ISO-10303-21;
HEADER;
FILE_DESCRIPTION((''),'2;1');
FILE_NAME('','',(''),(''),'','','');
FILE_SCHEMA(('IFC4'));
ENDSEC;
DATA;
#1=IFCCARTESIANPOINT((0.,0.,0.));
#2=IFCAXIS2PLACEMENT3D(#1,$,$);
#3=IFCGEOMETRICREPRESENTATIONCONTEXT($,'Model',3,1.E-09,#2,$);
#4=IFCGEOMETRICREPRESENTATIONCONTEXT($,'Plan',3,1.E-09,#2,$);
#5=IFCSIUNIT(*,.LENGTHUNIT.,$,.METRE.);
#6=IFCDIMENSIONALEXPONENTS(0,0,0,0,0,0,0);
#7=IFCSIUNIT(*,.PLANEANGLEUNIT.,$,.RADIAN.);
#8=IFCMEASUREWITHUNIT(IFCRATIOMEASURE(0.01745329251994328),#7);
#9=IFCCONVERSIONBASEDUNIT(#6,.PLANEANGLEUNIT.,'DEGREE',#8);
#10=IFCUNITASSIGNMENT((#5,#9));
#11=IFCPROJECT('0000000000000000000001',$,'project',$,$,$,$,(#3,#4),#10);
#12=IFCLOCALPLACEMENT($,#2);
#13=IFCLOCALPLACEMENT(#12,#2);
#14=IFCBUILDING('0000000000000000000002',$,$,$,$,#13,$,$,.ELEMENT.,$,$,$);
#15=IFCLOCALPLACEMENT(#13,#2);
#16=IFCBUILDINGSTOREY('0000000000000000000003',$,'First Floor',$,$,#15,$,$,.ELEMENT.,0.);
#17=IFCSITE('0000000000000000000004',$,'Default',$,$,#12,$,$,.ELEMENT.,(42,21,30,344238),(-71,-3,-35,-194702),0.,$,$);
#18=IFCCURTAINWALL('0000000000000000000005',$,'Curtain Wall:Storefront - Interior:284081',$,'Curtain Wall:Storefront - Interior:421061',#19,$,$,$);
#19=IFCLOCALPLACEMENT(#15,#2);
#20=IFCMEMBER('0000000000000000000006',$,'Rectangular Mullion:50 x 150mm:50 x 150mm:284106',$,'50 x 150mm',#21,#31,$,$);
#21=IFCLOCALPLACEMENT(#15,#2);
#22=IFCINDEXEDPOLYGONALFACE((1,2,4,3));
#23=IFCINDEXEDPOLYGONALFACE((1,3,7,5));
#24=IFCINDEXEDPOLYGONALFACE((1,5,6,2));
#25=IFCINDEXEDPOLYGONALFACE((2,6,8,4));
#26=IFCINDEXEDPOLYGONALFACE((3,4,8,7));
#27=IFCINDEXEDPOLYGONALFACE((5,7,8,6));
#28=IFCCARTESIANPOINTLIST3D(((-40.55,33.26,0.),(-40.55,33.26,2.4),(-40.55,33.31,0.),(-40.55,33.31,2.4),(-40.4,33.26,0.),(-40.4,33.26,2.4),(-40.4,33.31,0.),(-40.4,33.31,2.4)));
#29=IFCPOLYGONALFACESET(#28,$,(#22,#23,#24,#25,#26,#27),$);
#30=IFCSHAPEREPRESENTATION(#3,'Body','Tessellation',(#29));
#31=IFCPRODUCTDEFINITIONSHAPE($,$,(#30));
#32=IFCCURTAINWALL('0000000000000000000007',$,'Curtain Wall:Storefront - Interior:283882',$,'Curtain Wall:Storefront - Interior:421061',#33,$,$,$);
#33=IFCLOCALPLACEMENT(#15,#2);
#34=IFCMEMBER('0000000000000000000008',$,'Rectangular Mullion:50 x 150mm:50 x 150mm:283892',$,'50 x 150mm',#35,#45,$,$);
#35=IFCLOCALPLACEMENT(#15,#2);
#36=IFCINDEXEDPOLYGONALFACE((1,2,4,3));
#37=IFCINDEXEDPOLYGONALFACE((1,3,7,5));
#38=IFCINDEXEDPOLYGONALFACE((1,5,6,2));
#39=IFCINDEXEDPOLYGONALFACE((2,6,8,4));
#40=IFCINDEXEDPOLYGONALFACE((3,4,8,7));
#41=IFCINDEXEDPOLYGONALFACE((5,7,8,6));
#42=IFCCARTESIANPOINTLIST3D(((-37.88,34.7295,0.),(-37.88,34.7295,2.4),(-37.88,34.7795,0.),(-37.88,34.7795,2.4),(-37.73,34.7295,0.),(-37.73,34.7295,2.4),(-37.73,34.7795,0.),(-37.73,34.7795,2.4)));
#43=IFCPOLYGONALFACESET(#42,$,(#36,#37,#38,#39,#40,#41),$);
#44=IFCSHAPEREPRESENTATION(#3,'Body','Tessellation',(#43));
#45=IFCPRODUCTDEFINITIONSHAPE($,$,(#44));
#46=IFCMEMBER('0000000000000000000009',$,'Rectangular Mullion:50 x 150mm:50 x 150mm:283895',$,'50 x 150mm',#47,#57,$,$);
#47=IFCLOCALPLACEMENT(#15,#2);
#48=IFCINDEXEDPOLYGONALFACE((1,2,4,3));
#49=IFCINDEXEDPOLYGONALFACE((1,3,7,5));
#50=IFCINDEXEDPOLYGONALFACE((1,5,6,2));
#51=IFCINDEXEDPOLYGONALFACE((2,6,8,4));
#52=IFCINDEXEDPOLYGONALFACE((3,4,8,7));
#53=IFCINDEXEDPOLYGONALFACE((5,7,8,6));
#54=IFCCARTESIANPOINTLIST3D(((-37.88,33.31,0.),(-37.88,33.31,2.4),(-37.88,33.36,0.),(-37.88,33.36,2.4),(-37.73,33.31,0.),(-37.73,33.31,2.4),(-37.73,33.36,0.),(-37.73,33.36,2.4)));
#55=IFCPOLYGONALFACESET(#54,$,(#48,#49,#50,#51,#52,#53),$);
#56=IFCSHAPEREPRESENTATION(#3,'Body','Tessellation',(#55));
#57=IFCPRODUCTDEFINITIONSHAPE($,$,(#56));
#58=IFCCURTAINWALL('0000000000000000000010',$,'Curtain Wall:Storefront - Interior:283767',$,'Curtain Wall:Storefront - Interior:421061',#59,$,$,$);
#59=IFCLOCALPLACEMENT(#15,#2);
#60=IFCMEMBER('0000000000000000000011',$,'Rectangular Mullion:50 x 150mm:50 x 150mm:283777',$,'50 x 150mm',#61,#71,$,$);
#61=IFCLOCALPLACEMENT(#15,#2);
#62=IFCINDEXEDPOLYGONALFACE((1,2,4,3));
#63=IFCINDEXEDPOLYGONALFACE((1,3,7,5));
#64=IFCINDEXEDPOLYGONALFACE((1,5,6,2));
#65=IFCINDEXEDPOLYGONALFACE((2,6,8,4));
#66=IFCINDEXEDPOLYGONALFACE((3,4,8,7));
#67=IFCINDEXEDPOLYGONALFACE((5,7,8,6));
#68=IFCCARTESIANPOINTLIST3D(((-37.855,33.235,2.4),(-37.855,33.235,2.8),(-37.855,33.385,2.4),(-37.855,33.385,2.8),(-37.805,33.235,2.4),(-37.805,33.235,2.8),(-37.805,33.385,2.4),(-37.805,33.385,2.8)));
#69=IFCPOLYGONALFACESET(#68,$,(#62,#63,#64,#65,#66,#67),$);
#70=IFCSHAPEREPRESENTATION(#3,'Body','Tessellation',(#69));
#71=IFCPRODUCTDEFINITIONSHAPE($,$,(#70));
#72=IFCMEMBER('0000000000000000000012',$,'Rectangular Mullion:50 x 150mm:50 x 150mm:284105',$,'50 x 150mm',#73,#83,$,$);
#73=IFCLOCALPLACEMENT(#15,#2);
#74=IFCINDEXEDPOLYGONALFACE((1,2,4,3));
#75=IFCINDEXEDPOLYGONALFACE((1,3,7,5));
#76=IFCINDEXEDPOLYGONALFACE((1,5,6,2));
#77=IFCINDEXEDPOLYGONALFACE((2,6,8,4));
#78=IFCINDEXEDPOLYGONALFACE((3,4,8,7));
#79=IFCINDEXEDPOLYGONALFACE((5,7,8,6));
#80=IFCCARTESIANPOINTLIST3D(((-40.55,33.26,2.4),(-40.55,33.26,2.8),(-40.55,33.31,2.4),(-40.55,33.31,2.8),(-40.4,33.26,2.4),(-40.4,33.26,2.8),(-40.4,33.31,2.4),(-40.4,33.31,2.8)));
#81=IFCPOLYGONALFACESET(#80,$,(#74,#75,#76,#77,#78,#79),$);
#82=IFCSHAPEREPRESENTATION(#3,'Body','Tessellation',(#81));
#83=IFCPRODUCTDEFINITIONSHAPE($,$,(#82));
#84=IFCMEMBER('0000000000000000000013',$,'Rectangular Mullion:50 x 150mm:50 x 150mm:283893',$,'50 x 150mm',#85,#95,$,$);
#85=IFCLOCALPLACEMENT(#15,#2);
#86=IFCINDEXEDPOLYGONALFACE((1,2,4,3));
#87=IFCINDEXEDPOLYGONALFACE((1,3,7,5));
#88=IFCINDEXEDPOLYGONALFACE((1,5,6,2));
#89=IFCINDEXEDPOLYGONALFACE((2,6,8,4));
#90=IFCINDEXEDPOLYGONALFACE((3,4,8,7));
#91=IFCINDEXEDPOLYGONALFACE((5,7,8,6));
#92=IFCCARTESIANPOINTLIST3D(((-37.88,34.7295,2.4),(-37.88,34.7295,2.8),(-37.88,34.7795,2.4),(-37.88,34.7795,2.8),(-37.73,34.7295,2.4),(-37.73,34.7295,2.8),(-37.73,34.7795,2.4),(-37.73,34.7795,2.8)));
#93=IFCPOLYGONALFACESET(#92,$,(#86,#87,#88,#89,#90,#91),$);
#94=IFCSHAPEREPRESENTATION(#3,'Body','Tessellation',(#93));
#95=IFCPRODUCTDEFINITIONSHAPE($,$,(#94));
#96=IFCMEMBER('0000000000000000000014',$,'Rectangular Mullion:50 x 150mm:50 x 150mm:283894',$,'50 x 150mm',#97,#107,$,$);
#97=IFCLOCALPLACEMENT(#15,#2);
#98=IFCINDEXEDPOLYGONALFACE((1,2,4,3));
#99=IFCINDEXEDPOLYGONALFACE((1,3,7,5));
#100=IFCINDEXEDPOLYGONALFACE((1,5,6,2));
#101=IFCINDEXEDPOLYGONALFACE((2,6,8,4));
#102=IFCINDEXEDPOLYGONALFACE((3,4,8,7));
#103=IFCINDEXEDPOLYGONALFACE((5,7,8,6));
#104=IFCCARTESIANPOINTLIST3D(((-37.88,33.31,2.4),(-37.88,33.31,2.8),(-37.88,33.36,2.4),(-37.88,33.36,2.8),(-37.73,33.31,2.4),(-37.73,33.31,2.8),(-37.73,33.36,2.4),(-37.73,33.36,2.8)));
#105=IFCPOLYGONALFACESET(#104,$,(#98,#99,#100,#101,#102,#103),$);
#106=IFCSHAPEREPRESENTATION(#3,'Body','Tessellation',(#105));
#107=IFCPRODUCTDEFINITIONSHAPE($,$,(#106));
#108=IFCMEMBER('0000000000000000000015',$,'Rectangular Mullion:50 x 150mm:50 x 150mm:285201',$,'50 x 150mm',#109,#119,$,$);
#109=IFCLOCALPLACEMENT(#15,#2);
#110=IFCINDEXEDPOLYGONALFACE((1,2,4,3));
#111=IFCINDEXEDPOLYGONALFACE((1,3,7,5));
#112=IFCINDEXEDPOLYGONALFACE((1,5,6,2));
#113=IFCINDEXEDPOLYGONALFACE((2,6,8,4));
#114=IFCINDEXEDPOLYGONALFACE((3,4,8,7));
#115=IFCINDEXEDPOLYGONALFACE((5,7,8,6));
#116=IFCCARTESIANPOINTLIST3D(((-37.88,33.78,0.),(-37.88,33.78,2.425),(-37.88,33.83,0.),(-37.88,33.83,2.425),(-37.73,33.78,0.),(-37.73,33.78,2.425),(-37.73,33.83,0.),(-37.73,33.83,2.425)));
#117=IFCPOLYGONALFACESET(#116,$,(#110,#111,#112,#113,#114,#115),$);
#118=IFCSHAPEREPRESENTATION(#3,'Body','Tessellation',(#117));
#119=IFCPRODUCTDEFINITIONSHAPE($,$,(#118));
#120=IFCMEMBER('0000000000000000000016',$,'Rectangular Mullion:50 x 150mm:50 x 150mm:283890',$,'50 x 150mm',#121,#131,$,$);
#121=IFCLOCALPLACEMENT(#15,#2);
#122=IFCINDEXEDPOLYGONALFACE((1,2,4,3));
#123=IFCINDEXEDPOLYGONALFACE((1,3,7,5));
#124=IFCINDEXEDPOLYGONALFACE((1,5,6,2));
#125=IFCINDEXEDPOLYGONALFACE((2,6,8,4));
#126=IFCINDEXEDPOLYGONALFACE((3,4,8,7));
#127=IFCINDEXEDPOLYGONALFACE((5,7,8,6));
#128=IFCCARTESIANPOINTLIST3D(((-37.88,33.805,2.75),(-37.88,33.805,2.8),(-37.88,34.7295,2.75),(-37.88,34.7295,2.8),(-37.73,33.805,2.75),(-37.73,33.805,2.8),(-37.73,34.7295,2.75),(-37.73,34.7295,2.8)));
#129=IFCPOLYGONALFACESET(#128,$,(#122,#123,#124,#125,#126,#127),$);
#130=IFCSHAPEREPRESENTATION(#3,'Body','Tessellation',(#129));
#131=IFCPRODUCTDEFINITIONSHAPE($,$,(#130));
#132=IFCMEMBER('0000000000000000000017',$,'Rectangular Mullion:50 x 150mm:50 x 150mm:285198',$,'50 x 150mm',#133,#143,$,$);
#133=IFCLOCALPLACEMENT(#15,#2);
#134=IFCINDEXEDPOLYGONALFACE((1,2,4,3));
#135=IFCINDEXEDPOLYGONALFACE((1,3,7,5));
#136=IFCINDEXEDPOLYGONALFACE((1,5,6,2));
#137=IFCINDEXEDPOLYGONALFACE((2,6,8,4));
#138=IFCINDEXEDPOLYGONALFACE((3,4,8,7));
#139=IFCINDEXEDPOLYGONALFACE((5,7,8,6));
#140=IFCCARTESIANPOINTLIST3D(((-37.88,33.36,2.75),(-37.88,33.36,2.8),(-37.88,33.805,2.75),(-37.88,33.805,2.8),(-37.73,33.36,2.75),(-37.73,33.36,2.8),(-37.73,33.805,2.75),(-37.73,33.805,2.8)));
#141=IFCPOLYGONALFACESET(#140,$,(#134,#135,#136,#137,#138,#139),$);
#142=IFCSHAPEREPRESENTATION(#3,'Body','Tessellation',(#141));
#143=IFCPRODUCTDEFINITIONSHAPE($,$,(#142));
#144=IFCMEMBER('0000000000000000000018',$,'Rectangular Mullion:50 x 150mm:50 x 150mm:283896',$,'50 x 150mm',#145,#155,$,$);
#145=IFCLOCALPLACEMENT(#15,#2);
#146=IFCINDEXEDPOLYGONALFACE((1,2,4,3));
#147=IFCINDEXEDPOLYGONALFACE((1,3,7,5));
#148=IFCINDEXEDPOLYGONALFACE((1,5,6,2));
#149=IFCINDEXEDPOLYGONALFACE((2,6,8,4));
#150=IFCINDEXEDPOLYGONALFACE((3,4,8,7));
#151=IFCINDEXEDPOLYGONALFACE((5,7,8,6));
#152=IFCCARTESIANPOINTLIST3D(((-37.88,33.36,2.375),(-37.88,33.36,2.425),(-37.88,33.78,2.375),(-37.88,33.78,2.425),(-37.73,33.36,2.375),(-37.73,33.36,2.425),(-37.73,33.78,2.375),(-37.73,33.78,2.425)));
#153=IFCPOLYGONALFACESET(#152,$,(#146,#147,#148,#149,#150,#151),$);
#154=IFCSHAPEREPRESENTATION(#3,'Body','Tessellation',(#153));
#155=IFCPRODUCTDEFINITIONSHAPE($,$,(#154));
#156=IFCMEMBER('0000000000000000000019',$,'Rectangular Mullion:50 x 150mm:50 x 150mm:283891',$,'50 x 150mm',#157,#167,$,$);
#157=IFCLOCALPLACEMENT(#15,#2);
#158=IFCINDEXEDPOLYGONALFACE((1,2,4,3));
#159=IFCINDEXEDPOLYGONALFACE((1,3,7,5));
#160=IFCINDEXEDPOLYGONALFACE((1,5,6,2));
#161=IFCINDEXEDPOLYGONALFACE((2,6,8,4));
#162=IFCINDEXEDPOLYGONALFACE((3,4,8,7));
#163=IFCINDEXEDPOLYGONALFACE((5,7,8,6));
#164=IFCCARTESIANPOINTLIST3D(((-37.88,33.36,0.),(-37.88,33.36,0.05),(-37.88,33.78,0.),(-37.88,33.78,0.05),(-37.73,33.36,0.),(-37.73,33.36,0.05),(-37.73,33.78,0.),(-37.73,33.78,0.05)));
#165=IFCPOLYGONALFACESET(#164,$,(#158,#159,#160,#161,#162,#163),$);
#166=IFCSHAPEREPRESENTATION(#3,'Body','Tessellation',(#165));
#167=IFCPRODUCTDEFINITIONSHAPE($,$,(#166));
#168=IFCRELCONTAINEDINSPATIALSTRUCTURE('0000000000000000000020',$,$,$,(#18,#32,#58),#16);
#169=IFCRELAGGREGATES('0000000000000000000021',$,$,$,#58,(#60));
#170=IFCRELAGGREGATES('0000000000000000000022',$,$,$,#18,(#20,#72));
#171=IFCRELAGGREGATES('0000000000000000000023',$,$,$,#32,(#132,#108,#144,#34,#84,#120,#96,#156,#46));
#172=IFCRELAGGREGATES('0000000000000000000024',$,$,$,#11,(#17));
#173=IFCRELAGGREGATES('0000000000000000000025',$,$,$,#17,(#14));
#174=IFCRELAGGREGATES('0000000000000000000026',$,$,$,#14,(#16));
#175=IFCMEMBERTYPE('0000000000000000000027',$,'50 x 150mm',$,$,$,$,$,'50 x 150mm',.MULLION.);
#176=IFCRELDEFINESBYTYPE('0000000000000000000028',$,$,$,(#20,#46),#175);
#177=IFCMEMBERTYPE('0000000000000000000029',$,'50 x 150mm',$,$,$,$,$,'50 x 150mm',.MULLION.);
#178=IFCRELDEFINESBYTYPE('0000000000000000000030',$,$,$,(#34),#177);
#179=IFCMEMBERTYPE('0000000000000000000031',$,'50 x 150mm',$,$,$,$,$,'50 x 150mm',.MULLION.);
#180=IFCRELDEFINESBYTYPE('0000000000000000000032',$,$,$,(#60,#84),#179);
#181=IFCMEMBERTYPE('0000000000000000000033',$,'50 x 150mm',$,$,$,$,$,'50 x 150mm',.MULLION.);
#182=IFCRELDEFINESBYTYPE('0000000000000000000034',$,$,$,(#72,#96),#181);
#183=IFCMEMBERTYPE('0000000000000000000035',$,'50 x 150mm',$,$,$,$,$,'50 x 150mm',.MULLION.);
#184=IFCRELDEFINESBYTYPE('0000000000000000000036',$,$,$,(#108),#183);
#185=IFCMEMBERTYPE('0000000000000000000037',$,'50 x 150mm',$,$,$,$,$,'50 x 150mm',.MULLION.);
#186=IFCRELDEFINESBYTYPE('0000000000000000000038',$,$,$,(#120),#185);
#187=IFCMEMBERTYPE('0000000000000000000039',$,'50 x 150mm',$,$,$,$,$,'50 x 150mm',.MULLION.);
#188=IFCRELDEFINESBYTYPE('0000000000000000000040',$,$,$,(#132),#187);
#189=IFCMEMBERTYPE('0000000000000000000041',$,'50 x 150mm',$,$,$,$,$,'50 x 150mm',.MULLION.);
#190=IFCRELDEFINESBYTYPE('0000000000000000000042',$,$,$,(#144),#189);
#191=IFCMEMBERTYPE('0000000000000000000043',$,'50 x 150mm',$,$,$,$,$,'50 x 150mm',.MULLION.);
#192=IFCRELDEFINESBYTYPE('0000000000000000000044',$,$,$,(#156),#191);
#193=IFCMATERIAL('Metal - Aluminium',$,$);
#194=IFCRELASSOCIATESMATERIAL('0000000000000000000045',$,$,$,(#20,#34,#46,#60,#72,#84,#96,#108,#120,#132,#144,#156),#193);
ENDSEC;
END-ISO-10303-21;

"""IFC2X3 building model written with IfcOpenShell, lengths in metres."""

from ifc_helpers import new_model, entity, si_unit, converted_unit, frame, origin, origin_2d_with_axis, place, context, project, spatial, rectangle, extrude, source, transform, mapped, material, type_object, type_shapes, element, aggregate, save


model = new_model("IFC2X3")

# Units and contexts
model_context = context("Model", 3, precision=1e-09, world=origin())
plan_context = context("Plan", 3, precision=1e-09, world=origin())
ifc_project = project(units=[si_unit("LENGTHUNIT", "METRE"), converted_unit("PLANEANGLEUNIT", "DEGREE", entity("IfcRatioMeasure", 0.01745329251994328), si_unit("PLANEANGLEUNIT", "RADIAN"), dimensions=[0, 0, 0, 0, 0, 0, 0])], contexts=[model_context, plan_context])

# Site, building, storey
site_placement = place(None, origin())
site = spatial("IfcSite", under=ifc_project, at=site_placement, Name="Default", CompositionType="ELEMENT", RefLatitude=(42, 21, 30, 344238), RefLongitude=(-71, -3, -35, -194702), RefElevation=0.0)
building_placement = place(site_placement, origin())
building = spatial("IfcBuilding", under=site, at=building_placement, CompositionType="ELEMENT")
storey_placement = place(building_placement, origin())
storey = spatial("IfcBuildingStorey", under=building, at=storey_placement, Name="First Floor", CompositionType="ELEMENT", Elevation=0.0)

# Curtain wall, member
curtain_wall_1_placement = place(storey_placement, origin())
curtain_wall_1 = element("IfcCurtainWall", 1, at=curtain_wall_1_placement, inside=storey, Name="Curtain Wall:Storefront - Interior:284081", ObjectType="Curtain Wall:Storefront - Interior:421061")
ifc_material_1 = material(Name="Metal - Aluminium")
member_type_1 = type_object("IfcMemberType", Name="50 x 150mm", ElementType="50 x 150mm", PredefinedType="MULLION")
shared_shape_1 = source(origin(), model_context, "Body", "SweptSolid", [
    extrude(rectangle(XDim=0.05, YDim=0.15, at=origin_2d_with_axis()), frame((-0.025, 0.0, -2.4), z_axis=(0.0, 0.0, 1.0), x_axis=(-1.0, 0.0, 0.0)), (0.0, 0.0, 1.0), 2.4),
])
type_shapes(member_type_1, [shared_shape_1])
member_1_placement = place(storey_placement, frame((-40.475, 33.31, 2.4), z_axis=(0.0, 0.0, 1.0), x_axis=(0.0, 1.0, 0.0)))
member_1 = element("IfcMember", 2, at=member_1_placement, type_object=member_type_1, material=ifc_material_1, Name="Rectangular Mullion:50 x 150mm:50 x 150mm:284106", ObjectType="50 x 150mm", context=model_context, shape_type="MappedRepresentation", body=[
    mapped(shared_shape_1, transform((0.0, 0.0, 0.0), scale=1.0)),
])

# Curtain wall, members
curtain_wall_2_placement = place(storey_placement, origin())
curtain_wall_2 = element("IfcCurtainWall", 3, at=curtain_wall_2_placement, inside=storey, Name="Curtain Wall:Storefront - Interior:283882", ObjectType="Curtain Wall:Storefront - Interior:421061")
member_type_2 = type_object("IfcMemberType", Name="50 x 150mm", ElementType="50 x 150mm", PredefinedType="MULLION")
type_shapes(member_type_2, [shared_shape_1])
member_2_placement = place(storey_placement, frame((-37.805, 34.7795, 0.0), z_axis=(0.0, 0.0, -1.0), x_axis=(0.0, 1.0, 0.0)))
member_2 = element("IfcMember", 4, at=member_2_placement, type_object=member_type_2, material=ifc_material_1, Name="Rectangular Mullion:50 x 150mm:50 x 150mm:283892", ObjectType="50 x 150mm", context=model_context, shape_type="MappedRepresentation", body=[
    mapped(shared_shape_1, transform((0.0, 0.0, 0.0), scale=1.0)),
])
member_3_placement = place(storey_placement, frame((-37.805, 33.31, 2.4), z_axis=(0.0, 0.0, 1.0), x_axis=(0.0, -1.0, 0.0)))
member_3 = element("IfcMember", 5, at=member_3_placement, type_object=member_type_1, material=ifc_material_1, Name="Rectangular Mullion:50 x 150mm:50 x 150mm:283895", ObjectType="50 x 150mm", context=model_context, shape_type="MappedRepresentation", body=[
    mapped(shared_shape_1, transform((0.0, 0.0, 0.0), scale=1.0)),
])

# Curtain wall, member
curtain_wall_3_placement = place(storey_placement, origin())
curtain_wall_3 = element("IfcCurtainWall", 6, at=curtain_wall_3_placement, inside=storey, Name="Curtain Wall:Storefront - Interior:283767", ObjectType="Curtain Wall:Storefront - Interior:421061")
member_type_3 = type_object("IfcMemberType", Name="50 x 150mm", ElementType="50 x 150mm", PredefinedType="MULLION")
shared_shape_2 = source(origin(), model_context, "Body", "SweptSolid", [
    extrude(rectangle(XDim=0.05, YDim=0.15, at=origin_2d_with_axis()), frame((-0.025, 0.0, -0.4), z_axis=(0.0, 0.0, 1.0), x_axis=(-1.0, 0.0, 0.0)), (0.0, 0.0, 1.0), 0.4),
])
type_shapes(member_type_3, [shared_shape_2])
member_4_placement = place(storey_placement, frame((-37.805, 33.31, 2.4), z_axis=(0.0, 0.0, -1.0), x_axis=(1.0, 0.0, 0.0)))
member_4 = element("IfcMember", 7, at=member_4_placement, type_object=member_type_3, material=ifc_material_1, Name="Rectangular Mullion:50 x 150mm:50 x 150mm:283777", ObjectType="50 x 150mm", context=model_context, shape_type="MappedRepresentation", body=[
    mapped(shared_shape_2, transform((0.0, 0.0, 0.0), scale=1.0)),
])
aggregate(curtain_wall_3, [member_4])

# Members
member_type_4 = type_object("IfcMemberType", Name="50 x 150mm", ElementType="50 x 150mm", PredefinedType="MULLION")
type_shapes(member_type_4, [shared_shape_2])
member_5_placement = place(storey_placement, frame((-40.475, 33.31, 2.8), z_axis=(0.0, 0.0, 1.0), x_axis=(0.0, 1.0, 0.0)))
member_5 = element("IfcMember", 8, at=member_5_placement, type_object=member_type_4, material=ifc_material_1, Name="Rectangular Mullion:50 x 150mm:50 x 150mm:284105", ObjectType="50 x 150mm", context=model_context, shape_type="MappedRepresentation", body=[
    mapped(shared_shape_2, transform((0.0, 0.0, 0.0), scale=1.0)),
])
aggregate(curtain_wall_1, [member_1, member_5])
member_6_placement = place(storey_placement, frame((-37.805, 34.7795, 2.4), z_axis=(0.0, 0.0, -1.0), x_axis=(0.0, 1.0, 0.0)))
member_6 = element("IfcMember", 9, at=member_6_placement, type_object=member_type_3, material=ifc_material_1, Name="Rectangular Mullion:50 x 150mm:50 x 150mm:283893", ObjectType="50 x 150mm", context=model_context, shape_type="MappedRepresentation", body=[
    mapped(shared_shape_2, transform((0.0, 0.0, 0.0), scale=1.0)),
])
member_7_placement = place(storey_placement, frame((-37.805, 33.31, 2.8), z_axis=(0.0, 0.0, 1.0), x_axis=(0.0, -1.0, 0.0)))
member_7 = element("IfcMember", 10, at=member_7_placement, type_object=member_type_4, material=ifc_material_1, Name="Rectangular Mullion:50 x 150mm:50 x 150mm:283894", ObjectType="50 x 150mm", context=model_context, shape_type="MappedRepresentation", body=[
    mapped(shared_shape_2, transform((0.0, 0.0, 0.0), scale=1.0)),
])
member_type_5 = type_object("IfcMemberType", Name="50 x 150mm", ElementType="50 x 150mm", PredefinedType="MULLION")
shared_shape_3 = source(origin(), model_context, "Body", "SweptSolid", [
    extrude(rectangle(XDim=0.05, YDim=0.15, at=origin_2d_with_axis()), frame((0.0, 0.0, -2.425), z_axis=(0.0, 0.0, 1.0), x_axis=(-1.0, 0.0, 0.0)), (0.0, 0.0, 1.0), 2.425),
])
type_shapes(member_type_5, [shared_shape_3])
member_8_placement = place(storey_placement, frame((-37.805, 33.805, 0.0), z_axis=(0.0, 0.0, -1.0), x_axis=(0.0, 1.0, 0.0)))
member_8 = element("IfcMember", 11, at=member_8_placement, type_object=member_type_5, material=ifc_material_1, Name="Rectangular Mullion:50 x 150mm:50 x 150mm:285201", ObjectType="50 x 150mm", context=model_context, shape_type="MappedRepresentation", body=[
    mapped(shared_shape_3, transform((0.0, 0.0, 0.0), scale=1.0)),
])
member_type_6 = type_object("IfcMemberType", Name="50 x 150mm", ElementType="50 x 150mm", PredefinedType="MULLION")
shared_shape_4 = source(origin(), model_context, "Body", "SweptSolid", [
    extrude(rectangle(XDim=0.05, YDim=0.15, at=origin_2d_with_axis()), frame((-0.025, 0.0, -0.9245), z_axis=(0.0, 0.0, 1.0), x_axis=(-1.0, 0.0, 0.0)), (0.0, 0.0, 1.0), 0.9245),
])
type_shapes(member_type_6, [shared_shape_4])
member_9_placement = place(storey_placement, frame((-37.805, 34.7295, 2.8), z_axis=(0.0, 1.0, 0.0), x_axis=(0.0, 0.0, 1.0)))
member_9 = element("IfcMember", 12, at=member_9_placement, type_object=member_type_6, material=ifc_material_1, Name="Rectangular Mullion:50 x 150mm:50 x 150mm:283890", ObjectType="50 x 150mm", context=model_context, shape_type="MappedRepresentation", body=[
    mapped(shared_shape_4, transform((0.0, 0.0, 0.0), scale=1.0)),
])
member_type_7 = type_object("IfcMemberType", Name="50 x 150mm", ElementType="50 x 150mm", PredefinedType="MULLION")
shared_shape_5 = source(origin(), model_context, "Body", "SweptSolid", [
    extrude(rectangle(XDim=0.05, YDim=0.15, at=origin_2d_with_axis()), frame((-0.025, 0.0, -0.445), z_axis=(0.0, 0.0, 1.0), x_axis=(-1.0, 0.0, 0.0)), (0.0, 0.0, 1.0), 0.445),
])
type_shapes(member_type_7, [shared_shape_5])
member_10_placement = place(storey_placement, frame((-37.805, 33.805, 2.8), z_axis=(0.0, 1.0, 0.0), x_axis=(0.0, 0.0, 1.0)))
member_10 = element("IfcMember", 13, at=member_10_placement, type_object=member_type_7, material=ifc_material_1, Name="Rectangular Mullion:50 x 150mm:50 x 150mm:285198", ObjectType="50 x 150mm", context=model_context, shape_type="MappedRepresentation", body=[
    mapped(shared_shape_5, transform((0.0, 0.0, 0.0), scale=1.0)),
])
member_type_8 = type_object("IfcMemberType", Name="50 x 150mm", ElementType="50 x 150mm", PredefinedType="MULLION")
shared_shape_6 = source(origin(), model_context, "Body", "SweptSolid", [
    extrude(rectangle(XDim=0.05, YDim=0.15, at=origin_2d_with_axis()), frame((0.0, 0.0, -0.42), z_axis=(0.0, 0.0, 1.0), x_axis=(-1.0, 0.0, 0.0)), (0.0, 0.0, 1.0), 0.42),
])
type_shapes(member_type_8, [shared_shape_6])
member_11_placement = place(storey_placement, frame((-37.805, 33.78, 2.4), z_axis=(0.0, 1.0, 0.0), x_axis=(0.0, 0.0, 1.0)))
member_11 = element("IfcMember", 14, at=member_11_placement, type_object=member_type_8, material=ifc_material_1, Name="Rectangular Mullion:50 x 150mm:50 x 150mm:283896", ObjectType="50 x 150mm", context=model_context, shape_type="MappedRepresentation", body=[
    mapped(shared_shape_6, transform((0.0, 0.0, 0.0), scale=1.0)),
])
member_type_9 = type_object("IfcMemberType", Name="50 x 150mm", ElementType="50 x 150mm", PredefinedType="MULLION")
shared_shape_7 = source(origin(), model_context, "Body", "SweptSolid", [
    extrude(rectangle(XDim=0.05, YDim=0.15, at=origin_2d_with_axis()), frame((-0.025, 0.0, -0.42), z_axis=(0.0, 0.0, 1.0), x_axis=(-1.0, 0.0, 0.0)), (0.0, 0.0, 1.0), 0.42),
])
type_shapes(member_type_9, [shared_shape_7])
member_12_placement = place(storey_placement, frame((-37.805, 33.36, 0.0), z_axis=(0.0, -1.0, 0.0), x_axis=(0.0, 0.0, -1.0)))
member_12 = element("IfcMember", 15, at=member_12_placement, type_object=member_type_9, material=ifc_material_1, Name="Rectangular Mullion:50 x 150mm:50 x 150mm:283891", ObjectType="50 x 150mm", context=model_context, shape_type="MappedRepresentation", body=[
    mapped(shared_shape_7, transform((0.0, 0.0, 0.0), scale=1.0)),
])

aggregate(curtain_wall_2, [member_10, member_8, member_11, member_2, member_6, member_9, member_7, member_12, member_3])

save(model, "model.ifc")
